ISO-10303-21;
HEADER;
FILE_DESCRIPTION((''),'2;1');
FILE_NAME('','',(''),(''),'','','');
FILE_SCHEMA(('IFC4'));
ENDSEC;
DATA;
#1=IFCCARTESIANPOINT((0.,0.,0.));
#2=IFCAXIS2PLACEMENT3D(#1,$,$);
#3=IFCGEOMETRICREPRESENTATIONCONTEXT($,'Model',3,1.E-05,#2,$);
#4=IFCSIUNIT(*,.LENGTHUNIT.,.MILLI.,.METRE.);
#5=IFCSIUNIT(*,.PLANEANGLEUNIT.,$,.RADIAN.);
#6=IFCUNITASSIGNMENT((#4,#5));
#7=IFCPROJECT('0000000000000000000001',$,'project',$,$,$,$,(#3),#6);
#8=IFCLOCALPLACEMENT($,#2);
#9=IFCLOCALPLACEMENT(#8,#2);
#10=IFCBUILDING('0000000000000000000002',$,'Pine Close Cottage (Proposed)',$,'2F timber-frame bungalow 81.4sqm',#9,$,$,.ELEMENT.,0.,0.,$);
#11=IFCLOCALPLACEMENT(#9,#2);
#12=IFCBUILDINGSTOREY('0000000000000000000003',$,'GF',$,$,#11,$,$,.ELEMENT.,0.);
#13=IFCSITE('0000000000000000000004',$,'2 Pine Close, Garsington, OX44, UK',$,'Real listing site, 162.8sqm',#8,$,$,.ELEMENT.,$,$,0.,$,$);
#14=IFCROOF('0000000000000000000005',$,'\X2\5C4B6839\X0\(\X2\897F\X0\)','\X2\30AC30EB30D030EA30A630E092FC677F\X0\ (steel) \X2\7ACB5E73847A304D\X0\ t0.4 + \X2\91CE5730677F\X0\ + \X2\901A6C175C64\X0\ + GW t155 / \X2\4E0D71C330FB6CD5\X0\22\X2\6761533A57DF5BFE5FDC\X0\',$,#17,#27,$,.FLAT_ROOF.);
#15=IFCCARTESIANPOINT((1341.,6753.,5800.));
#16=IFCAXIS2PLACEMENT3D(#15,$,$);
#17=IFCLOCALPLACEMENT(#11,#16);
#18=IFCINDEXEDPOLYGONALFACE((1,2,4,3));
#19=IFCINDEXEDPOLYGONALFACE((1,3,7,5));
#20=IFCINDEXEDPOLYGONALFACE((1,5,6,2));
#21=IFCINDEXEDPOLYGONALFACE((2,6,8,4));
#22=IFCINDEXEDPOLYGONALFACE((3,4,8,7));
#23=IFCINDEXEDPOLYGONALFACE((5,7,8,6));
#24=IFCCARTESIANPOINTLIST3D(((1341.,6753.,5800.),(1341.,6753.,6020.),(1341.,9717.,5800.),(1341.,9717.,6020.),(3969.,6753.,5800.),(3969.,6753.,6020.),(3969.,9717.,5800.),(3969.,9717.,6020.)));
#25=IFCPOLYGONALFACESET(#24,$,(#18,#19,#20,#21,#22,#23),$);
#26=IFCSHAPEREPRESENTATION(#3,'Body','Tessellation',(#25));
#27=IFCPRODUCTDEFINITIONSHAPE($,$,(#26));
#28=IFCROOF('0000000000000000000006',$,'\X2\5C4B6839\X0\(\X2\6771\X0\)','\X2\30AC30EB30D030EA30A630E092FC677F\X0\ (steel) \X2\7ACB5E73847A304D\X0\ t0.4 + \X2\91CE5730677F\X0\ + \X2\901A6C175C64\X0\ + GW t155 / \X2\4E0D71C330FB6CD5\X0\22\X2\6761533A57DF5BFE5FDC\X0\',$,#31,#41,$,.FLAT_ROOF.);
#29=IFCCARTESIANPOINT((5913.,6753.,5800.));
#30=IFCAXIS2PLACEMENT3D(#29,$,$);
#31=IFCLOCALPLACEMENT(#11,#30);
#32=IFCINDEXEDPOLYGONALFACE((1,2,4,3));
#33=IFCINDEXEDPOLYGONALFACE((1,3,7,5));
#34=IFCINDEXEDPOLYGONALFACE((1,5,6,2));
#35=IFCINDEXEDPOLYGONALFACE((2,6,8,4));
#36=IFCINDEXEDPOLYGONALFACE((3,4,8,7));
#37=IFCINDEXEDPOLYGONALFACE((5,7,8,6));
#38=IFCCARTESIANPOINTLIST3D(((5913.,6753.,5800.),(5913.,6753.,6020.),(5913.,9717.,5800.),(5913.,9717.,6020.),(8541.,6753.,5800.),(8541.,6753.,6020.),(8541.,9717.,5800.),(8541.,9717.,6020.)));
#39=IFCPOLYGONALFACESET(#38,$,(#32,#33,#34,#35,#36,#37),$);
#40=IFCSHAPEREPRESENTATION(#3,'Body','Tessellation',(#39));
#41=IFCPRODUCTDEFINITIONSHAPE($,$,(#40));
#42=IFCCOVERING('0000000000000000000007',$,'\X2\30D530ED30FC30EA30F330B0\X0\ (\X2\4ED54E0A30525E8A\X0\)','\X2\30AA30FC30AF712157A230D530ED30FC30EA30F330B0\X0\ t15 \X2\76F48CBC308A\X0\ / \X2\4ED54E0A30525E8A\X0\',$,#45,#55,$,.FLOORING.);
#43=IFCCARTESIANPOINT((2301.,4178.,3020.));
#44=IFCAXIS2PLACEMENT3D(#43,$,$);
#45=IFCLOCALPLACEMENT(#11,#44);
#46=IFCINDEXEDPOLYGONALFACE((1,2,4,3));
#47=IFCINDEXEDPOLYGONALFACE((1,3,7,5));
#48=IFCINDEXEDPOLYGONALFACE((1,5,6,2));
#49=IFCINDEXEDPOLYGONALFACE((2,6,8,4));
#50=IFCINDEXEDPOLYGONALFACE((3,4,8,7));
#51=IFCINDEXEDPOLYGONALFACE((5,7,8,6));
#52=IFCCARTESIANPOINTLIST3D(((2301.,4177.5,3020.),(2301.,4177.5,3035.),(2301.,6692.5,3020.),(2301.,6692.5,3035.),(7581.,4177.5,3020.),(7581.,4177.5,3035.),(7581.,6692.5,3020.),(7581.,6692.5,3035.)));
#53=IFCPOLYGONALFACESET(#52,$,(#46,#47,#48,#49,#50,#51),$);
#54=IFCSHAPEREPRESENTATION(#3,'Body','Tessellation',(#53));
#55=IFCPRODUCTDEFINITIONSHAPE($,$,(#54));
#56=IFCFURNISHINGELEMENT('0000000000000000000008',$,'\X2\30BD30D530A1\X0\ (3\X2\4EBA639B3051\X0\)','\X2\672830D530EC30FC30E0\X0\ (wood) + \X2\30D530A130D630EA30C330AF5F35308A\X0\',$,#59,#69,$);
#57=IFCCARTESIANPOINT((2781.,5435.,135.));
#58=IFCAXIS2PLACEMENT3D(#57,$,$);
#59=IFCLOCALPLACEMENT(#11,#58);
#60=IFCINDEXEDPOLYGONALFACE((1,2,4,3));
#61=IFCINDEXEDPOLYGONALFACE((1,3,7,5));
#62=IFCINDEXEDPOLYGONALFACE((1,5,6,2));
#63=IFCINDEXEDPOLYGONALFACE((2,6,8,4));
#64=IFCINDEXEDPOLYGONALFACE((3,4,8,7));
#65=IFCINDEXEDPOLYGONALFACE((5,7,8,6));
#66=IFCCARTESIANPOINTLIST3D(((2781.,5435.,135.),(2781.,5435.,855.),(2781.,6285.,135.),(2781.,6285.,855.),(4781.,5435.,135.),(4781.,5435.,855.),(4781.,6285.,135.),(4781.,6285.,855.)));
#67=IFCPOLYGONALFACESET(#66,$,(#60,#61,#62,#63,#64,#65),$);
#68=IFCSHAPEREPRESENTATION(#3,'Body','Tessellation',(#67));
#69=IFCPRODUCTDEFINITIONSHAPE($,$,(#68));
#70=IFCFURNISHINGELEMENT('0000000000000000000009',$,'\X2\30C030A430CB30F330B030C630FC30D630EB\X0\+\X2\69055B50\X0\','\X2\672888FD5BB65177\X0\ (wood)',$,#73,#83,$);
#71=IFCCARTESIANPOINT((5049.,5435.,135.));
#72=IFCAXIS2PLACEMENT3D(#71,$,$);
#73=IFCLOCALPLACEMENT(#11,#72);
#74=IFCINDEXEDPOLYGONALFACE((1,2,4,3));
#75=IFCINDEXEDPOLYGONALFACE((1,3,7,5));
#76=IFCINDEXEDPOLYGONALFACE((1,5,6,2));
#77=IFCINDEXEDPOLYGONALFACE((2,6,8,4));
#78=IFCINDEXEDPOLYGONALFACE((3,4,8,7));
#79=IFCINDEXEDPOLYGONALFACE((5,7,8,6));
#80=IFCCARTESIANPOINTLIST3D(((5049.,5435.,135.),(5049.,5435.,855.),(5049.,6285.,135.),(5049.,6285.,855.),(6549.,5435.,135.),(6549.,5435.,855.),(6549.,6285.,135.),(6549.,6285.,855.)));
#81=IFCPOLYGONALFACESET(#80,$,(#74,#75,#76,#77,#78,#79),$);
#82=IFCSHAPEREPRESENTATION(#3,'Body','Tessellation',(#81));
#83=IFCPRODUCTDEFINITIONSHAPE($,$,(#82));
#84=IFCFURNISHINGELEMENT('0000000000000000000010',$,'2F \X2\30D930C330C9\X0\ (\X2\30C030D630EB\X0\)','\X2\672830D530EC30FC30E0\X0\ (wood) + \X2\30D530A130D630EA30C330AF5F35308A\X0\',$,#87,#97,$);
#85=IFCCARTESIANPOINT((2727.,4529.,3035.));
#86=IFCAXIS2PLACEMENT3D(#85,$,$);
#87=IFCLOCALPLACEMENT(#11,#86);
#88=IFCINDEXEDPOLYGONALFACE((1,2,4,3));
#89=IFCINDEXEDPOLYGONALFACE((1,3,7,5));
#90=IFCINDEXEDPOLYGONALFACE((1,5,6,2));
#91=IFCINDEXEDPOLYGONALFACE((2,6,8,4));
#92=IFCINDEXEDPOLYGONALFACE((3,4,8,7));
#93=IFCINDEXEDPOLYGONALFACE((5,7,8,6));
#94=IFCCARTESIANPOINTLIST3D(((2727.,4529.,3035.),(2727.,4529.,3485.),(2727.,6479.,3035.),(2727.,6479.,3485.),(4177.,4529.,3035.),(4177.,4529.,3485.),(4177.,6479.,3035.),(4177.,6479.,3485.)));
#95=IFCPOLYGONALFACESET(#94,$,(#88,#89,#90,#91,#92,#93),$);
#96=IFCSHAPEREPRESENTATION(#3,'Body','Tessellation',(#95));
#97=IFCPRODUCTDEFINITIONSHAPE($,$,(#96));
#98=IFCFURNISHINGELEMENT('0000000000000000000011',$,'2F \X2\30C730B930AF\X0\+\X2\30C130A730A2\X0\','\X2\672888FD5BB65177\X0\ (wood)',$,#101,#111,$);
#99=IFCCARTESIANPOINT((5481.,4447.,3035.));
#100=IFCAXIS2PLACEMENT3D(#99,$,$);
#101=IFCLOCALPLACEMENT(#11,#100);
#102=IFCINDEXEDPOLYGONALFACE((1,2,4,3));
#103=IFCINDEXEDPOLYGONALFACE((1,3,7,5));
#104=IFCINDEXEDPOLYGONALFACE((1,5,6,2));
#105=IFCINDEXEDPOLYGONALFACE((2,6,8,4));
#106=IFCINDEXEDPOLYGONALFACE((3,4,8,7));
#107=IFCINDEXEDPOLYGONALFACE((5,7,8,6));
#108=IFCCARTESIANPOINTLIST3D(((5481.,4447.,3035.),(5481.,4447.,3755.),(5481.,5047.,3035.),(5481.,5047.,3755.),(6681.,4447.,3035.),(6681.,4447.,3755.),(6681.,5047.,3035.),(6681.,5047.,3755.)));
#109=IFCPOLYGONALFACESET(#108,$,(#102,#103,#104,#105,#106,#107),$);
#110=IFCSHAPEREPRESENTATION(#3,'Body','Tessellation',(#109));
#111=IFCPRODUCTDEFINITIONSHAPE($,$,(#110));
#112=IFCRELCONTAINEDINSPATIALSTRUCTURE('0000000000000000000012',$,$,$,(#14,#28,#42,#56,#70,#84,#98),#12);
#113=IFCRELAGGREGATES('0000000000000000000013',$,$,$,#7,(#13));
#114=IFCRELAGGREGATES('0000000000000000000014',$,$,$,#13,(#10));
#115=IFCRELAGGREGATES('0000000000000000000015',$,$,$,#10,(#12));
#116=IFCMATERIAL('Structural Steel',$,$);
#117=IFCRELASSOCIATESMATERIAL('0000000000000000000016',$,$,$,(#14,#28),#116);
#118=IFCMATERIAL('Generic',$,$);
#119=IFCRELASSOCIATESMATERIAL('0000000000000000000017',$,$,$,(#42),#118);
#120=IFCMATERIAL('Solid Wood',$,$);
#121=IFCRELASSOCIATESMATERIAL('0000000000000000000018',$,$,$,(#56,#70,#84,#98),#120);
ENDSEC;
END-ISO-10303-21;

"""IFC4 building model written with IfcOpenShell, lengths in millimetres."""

from ifc_helpers import new_model, si_unit, frame, frame_2d, origin, place, context, project, spatial, rectangle, extrude, material, element, save


model = new_model("IFC4")

# Units and contexts
model_context = context("Model", 3, precision=1e-05, world=origin())
ifc_project = project(units=[si_unit("LENGTHUNIT", "METRE", prefix="MILLI"), si_unit("PLANEANGLEUNIT", "RADIAN")], contexts=[model_context])

# Site, building, storey
site_placement = place(None, origin())
site = spatial("IfcSite", under=ifc_project, at=site_placement, Name="2 Pine Close, Garsington, OX44, UK", ObjectType="Real listing site, 162.8sqm", CompositionType="ELEMENT", RefElevation=0.0)
building_placement = place(site_placement, origin())
building = spatial("IfcBuilding", under=site, at=building_placement, Name="Pine Close Cottage (Proposed)", ObjectType="2F timber-frame bungalow 81.4sqm", CompositionType="ELEMENT", ElevationOfRefHeight=0.0, ElevationOfTerrain=0.0)
storey_placement = place(building_placement, origin())
storey = spatial("IfcBuildingStorey", under=building, at=storey_placement, Name="GF", CompositionType="ELEMENT", Elevation=0.0)

# Shared definitions
ifc_material_1 = material(Name="Solid Wood")

# Roofs
ifc_material_2 = material(Name="Structural Steel")
roof_1_placement = place(storey_placement, frame((1341.0, 6753.0, 5800.0)))
element("IfcRoof", 1, at=roof_1_placement, inside=storey, material=ifc_material_2, Name="屋根(西)", Description="ガルバリウム鋼板 (steel) 立平葺き t0.4 + 野地板 + 通気層 + GW t155 / 不燃・法22条区域対応", PredefinedType="FLAT_ROOF", context=model_context, shape_type="SweptSolid", body=[
    extrude(rectangle(XDim=2628.0, YDim=2964.0, at=frame_2d((1314.0, 1482.0))), frame((1341.0, 6753.0, 5800.0)), (0.0, 0.0, 1.0), 220.0),
])
roof_2_placement = place(storey_placement, frame((5913.0, 6753.0, 5800.0)))
element("IfcRoof", 2, at=roof_2_placement, inside=storey, material=ifc_material_2, Name="屋根(東)", Description="ガルバリウム鋼板 (steel) 立平葺き t0.4 + 野地板 + 通気層 + GW t155 / 不燃・法22条区域対応", PredefinedType="FLAT_ROOF", context=model_context, shape_type="SweptSolid", body=[
    extrude(rectangle(XDim=2628.0, YDim=2964.0, at=frame_2d((1314.0, 1482.0))), frame((5913.0, 6753.0, 5800.0)), (0.0, 0.0, 1.0), 220.0),
])

# Covering
ifc_material_3 = material(Name="Generic")
covering_placement = place(storey_placement, frame((2301.0, 4178.0, 3020.0)))
element("IfcCovering", 3, at=covering_placement, inside=storey, material=ifc_material_3, Name="フローリング (仕上げ床)", Description="オーク無垢フローリング t15 直貼り / 仕上げ床", PredefinedType="FLOORING", context=model_context, shape_type="SweptSolid", body=[
    extrude(rectangle(XDim=5280.0, YDim=2515.0, at=frame_2d((2640.0, 1257.0))), frame((2301.0, 4178.0, 3020.0)), (0.0, 0.0, 1.0), 15.0),
])

# Furnishing elements
furnishing_1_placement = place(storey_placement, frame((2781.0, 5435.0, 135.0)))
element("IfcFurnishingElement", 4, at=furnishing_1_placement, inside=storey, material=ifc_material_1, Name="ソファ (3人掛け)", Description="木フレーム (wood) + ファブリック張り", context=model_context, shape_type="SweptSolid", body=[
    extrude(rectangle(XDim=2000.0, YDim=850.0, at=frame_2d((1000.0, 425.0))), frame((2781.0, 5435.0, 135.0)), (0.0, 0.0, 1.0), 720.0),
])
furnishing_2_placement = place(storey_placement, frame((5049.0, 5435.0, 135.0)))
element("IfcFurnishingElement", 5, at=furnishing_2_placement, inside=storey, material=ifc_material_1, Name="ダイニングテーブル+椅子", Description="木製家具 (wood)", context=model_context, shape_type="SweptSolid", body=[
    extrude(rectangle(XDim=1500.0, YDim=850.0, at=frame_2d((750.0, 425.0))), frame((5049.0, 5435.0, 135.0)), (0.0, 0.0, 1.0), 720.0),
])
furnishing_3_placement = place(storey_placement, frame((2727.0, 4529.0, 3035.0)))
element("IfcFurnishingElement", 6, at=furnishing_3_placement, inside=storey, material=ifc_material_1, Name="2F ベッド (ダブル)", Description="木フレーム (wood) + ファブリック張り", context=model_context, shape_type="SweptSolid", body=[
    extrude(rectangle(XDim=1450.0, YDim=1950.0, at=frame_2d((725.0, 975.0))), frame((2727.0, 4529.0, 3035.0)), (0.0, 0.0, 1.0), 450.0),
])
furnishing_4_placement = place(storey_placement, frame((5481.0, 4447.0, 3035.0)))
element("IfcFurnishingElement", 7, at=furnishing_4_placement, inside=storey, material=ifc_material_1, Name="2F デスク+チェア", Description="木製家具 (wood)", context=model_context, shape_type="SweptSolid", body=[
    extrude(rectangle(XDim=1200.0, YDim=600.0, at=frame_2d((600.0, 300.0))), frame((5481.0, 4447.0, 3035.0)), (0.0, 0.0, 1.0), 720.0),
])

save(model, "model.ifc")
